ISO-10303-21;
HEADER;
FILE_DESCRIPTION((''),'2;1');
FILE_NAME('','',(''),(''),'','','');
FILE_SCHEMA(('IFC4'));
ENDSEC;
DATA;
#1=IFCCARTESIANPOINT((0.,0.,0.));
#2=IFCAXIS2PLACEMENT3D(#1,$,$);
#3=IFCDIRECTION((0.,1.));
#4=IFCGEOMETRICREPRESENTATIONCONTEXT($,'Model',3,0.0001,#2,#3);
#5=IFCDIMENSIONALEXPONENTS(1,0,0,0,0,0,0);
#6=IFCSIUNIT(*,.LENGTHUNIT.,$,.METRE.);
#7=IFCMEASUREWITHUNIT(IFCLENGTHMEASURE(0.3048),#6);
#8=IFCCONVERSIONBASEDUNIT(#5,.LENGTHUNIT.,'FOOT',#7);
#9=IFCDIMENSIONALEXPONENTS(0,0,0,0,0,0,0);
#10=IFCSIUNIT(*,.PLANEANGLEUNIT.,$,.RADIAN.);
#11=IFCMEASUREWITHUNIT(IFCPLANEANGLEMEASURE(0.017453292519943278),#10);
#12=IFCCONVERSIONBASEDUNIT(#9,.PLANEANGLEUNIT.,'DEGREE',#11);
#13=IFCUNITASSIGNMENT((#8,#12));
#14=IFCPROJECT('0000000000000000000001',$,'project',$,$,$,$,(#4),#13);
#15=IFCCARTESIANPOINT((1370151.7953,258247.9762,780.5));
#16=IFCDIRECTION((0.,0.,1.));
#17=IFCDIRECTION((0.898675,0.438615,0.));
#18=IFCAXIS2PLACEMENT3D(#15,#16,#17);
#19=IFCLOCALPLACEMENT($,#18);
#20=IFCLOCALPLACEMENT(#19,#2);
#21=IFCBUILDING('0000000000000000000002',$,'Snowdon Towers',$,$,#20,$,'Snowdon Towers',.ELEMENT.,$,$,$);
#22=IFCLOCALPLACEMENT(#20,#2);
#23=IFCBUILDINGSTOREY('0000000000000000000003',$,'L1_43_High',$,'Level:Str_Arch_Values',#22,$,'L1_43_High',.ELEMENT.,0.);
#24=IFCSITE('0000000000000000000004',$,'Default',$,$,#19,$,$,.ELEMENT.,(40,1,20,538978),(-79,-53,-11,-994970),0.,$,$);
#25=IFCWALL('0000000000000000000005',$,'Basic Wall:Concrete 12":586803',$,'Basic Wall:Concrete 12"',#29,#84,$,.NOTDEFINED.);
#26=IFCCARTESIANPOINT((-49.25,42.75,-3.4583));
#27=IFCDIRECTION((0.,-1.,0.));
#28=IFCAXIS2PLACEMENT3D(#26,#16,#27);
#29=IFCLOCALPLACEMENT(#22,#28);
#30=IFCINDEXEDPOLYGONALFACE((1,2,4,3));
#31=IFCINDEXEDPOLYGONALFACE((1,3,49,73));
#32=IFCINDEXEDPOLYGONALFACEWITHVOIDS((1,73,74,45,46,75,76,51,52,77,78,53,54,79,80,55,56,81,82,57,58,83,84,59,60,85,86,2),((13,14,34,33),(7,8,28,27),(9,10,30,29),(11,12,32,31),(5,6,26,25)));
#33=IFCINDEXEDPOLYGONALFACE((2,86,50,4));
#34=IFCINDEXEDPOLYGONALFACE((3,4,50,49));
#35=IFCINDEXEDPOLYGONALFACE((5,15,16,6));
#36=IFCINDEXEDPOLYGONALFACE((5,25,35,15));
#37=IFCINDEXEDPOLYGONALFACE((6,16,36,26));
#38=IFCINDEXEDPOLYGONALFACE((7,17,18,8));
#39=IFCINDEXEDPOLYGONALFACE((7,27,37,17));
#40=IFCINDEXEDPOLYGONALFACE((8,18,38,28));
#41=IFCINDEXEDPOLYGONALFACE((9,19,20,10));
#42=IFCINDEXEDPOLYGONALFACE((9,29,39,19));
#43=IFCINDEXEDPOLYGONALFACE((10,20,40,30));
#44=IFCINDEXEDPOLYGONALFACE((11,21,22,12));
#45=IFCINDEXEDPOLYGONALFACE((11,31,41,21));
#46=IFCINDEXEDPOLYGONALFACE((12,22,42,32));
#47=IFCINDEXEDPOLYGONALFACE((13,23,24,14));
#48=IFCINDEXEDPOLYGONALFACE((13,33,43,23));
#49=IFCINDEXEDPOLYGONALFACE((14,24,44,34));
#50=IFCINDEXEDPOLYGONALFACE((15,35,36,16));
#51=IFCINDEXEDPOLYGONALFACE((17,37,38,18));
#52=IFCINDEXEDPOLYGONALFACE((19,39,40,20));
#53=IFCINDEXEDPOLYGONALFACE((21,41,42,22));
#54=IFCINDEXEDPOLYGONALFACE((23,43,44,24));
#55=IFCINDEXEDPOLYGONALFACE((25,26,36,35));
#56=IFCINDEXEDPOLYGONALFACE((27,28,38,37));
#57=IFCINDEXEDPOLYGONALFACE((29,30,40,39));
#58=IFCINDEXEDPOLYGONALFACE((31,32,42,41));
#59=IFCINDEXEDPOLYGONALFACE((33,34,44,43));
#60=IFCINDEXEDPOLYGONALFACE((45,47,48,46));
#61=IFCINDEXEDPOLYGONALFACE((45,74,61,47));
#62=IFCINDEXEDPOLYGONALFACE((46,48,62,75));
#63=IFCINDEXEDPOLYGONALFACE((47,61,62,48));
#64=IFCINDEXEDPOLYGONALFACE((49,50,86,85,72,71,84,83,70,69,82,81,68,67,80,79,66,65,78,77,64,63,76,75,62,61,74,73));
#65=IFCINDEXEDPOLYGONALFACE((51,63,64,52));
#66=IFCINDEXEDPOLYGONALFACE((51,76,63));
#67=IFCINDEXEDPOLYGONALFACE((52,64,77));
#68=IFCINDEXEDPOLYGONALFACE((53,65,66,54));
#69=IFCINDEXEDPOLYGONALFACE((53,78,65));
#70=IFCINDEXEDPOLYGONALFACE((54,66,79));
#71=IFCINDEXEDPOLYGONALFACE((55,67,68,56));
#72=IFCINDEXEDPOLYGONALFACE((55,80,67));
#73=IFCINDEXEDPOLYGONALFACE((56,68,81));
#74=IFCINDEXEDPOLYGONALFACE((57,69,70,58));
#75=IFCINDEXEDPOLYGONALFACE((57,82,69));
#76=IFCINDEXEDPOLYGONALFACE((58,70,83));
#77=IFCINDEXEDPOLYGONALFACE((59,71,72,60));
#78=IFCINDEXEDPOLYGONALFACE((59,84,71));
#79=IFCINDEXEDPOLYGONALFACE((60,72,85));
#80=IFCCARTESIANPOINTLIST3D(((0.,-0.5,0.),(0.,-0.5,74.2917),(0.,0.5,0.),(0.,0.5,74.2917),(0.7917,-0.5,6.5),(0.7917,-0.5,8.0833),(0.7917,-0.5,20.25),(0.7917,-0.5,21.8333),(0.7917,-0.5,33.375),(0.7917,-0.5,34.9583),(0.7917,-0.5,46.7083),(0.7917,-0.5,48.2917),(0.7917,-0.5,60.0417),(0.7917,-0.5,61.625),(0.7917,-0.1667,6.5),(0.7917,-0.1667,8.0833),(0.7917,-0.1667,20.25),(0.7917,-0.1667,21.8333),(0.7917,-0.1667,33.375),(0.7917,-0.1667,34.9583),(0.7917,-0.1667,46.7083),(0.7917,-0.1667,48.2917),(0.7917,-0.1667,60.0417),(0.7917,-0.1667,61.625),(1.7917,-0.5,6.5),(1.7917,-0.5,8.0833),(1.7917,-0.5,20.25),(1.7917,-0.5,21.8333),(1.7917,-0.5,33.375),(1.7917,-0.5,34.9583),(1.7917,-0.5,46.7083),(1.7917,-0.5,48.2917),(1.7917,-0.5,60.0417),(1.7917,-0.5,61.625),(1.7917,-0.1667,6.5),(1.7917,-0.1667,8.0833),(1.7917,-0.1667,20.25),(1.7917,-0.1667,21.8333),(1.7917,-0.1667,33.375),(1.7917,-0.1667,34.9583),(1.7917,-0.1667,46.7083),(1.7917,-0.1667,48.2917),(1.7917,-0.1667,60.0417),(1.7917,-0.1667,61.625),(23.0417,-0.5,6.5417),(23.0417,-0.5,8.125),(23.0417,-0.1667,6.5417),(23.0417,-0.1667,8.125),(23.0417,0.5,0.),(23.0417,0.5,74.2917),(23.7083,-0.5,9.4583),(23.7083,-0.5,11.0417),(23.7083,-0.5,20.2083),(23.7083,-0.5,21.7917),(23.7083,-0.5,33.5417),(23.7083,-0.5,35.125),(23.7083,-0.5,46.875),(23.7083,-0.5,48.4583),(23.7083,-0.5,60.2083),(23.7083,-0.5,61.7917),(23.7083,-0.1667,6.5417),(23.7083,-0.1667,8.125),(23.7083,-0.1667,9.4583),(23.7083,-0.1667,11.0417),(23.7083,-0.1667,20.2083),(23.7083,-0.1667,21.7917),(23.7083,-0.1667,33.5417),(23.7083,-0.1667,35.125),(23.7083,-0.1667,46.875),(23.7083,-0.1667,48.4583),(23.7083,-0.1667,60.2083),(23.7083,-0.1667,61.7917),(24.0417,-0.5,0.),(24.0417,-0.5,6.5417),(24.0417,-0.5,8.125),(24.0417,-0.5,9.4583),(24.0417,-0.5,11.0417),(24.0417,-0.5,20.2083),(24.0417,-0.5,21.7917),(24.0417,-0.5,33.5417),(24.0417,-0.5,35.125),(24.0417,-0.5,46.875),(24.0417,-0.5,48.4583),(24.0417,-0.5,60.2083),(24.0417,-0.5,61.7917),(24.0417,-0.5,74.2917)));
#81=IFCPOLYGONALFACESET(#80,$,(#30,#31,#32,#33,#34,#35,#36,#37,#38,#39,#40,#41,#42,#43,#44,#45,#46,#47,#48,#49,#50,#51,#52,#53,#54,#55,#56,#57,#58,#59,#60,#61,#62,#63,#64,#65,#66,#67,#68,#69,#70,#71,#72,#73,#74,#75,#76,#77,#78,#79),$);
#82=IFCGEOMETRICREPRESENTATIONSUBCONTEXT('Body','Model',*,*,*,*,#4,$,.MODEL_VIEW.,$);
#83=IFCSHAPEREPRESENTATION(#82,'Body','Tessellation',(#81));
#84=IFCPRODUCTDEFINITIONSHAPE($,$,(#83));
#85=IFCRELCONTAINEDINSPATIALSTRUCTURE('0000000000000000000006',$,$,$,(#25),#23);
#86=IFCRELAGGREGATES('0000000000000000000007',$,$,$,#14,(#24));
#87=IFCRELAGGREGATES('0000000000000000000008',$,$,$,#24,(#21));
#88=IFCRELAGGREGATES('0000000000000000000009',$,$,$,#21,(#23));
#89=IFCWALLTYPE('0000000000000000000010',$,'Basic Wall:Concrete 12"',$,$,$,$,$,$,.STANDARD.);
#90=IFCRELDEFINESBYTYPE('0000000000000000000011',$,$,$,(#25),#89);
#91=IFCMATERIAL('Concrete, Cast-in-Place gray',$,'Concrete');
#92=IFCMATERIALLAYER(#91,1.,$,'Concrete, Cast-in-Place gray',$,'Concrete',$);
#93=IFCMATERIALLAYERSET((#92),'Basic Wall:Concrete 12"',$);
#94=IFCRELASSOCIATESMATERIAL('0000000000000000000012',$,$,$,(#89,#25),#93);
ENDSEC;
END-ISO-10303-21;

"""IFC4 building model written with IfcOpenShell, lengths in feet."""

from ifc_helpers import new_model, entity, si_unit, converted_unit, direction, frame, frame_2d, origin, origin_2d_with_axis, place, context, subcontext, project, spatial, polyline, rectangle, outline, extrude, material, layer, layer_set, layer_usage, type_object, element, save


model = new_model("IFC4")

# Units and contexts
model_context = context("Model", 3, precision=0.0001, world=origin(), true_north=direction((0.0, 1.0)))
body_context = subcontext(model_context, "Body", "Model", "MODEL_VIEW")
ifc_project = project(units=[converted_unit("LENGTHUNIT", "FOOT", entity("IfcLengthMeasure", 0.3048), si_unit("LENGTHUNIT", "METRE"), dimensions=[1, 0, 0, 0, 0, 0, 0]), converted_unit("PLANEANGLEUNIT", "DEGREE", entity("IfcPlaneAngleMeasure", 0.017453292519943278), si_unit("PLANEANGLEUNIT", "RADIAN"), dimensions=[0, 0, 0, 0, 0, 0, 0])], contexts=[model_context])

# Site, building, storey
site_placement = place(None, frame((1370151.7953, 258247.9762, 780.5), z_axis=(0.0, 0.0, 1.0), x_axis=(0.898675, 0.438615, 0.0)))
site = spatial("IfcSite", under=ifc_project, at=site_placement, Name="Default", CompositionType="ELEMENT", RefLatitude=(40, 1, 20, 538978), RefLongitude=(-79, -53, -11, -994970), RefElevation=0.0)
building_placement = place(site_placement, origin())
building = spatial("IfcBuilding", under=site, at=building_placement, Name="Snowdon Towers", LongName="Snowdon Towers", CompositionType="ELEMENT")
storey_placement = place(building_placement, origin())
storey = spatial("IfcBuildingStorey", under=building, at=storey_placement, Name="L1_43_High", ObjectType="Level:Str_Arch_Values", LongName="L1_43_High", CompositionType="ELEMENT", Elevation=0.0)

# Shared definitions
ifc_material = material(Name="Concrete, Cast-in-Place gray", Category="Concrete")
ifc_layer = layer(ifc_material, 1.0, Name="Concrete, Cast-in-Place gray", Category="Concrete")
ifc_layer_set = layer_set([ifc_layer], Name="Basic Wall:Concrete 12\"")
wall_type = type_object("IfcWallType", Name="Basic Wall:Concrete 12\"", PredefinedType="STANDARD", material=ifc_layer_set)

# Wall, openings
ifc_layer_usage_1 = layer_usage(ifc_layer_set, "AXIS2", "POSITIVE", -0.5)
wall_1_placement = place(storey_placement, frame((-49.25, 42.75, -3.4583), z_axis=(0.0, 0.0, 1.0), x_axis=(0.0, -1.0, 0.0)))
wall_1 = element("IfcWall", 1, at=wall_1_placement, inside=storey, type_object=wall_type, material=ifc_layer_usage_1, Name="Basic Wall:Concrete 12\":586803", ObjectType="Basic Wall:Concrete 12\"", PredefinedType="NOTDEFINED", context=body_context, shape_type="SweptSolid", body=[
    extrude(outline(polyline([(24.0417, -0.5), (23.0417, 0.5), (0.0, 0.5), (0.0, -0.5), (24.0417, -0.5)])), origin(), (0.0, 0.0, 1.0), 74.2917),
])
opening_1_placement = place(wall_1_placement, origin())
element("IfcOpeningElement", 2, at=opening_1_placement, cuts=wall_1, PredefinedType="OPENING", context=body_context, shape_type="SweptSolid", body=[
    extrude(rectangle(XDim=1.5833, YDim=0.3333, at=frame_2d((0.0, 0.0), x_axis=(0.0, 1.0))), frame((23.875, -0.5, 21.0), z_axis=(0.0, 1.0, 0.0), x_axis=(1.0, 0.0, 0.0)), (0.0, 0.0, 1.0), 1.0),
])
opening_2_placement = place(wall_1_placement, origin())
element("IfcOpeningElement", 3, at=opening_2_placement, cuts=wall_1, PredefinedType="OPENING", context=body_context, shape_type="SweptSolid", body=[
    extrude(rectangle(XDim=1.5833, YDim=0.3333, at=frame_2d((0.0, 0.0), x_axis=(0.0, 1.0))), frame((23.875, -0.5, 10.25), z_axis=(0.0, 1.0, 0.0), x_axis=(1.0, 0.0, 0.0)), (0.0, 0.0, 1.0), 1.0),
])
opening_3_placement = place(wall_1_placement, origin())
element("IfcOpeningElement", 4, at=opening_3_placement, cuts=wall_1, PredefinedType="RECESS", context=body_context, shape_type="SweptSolid", body=[
    extrude(rectangle(XDim=1.5833, YDim=1.0, at=frame_2d((0.0, 0.0), x_axis=(1.0, 0.0))), frame((23.5417, -0.5, 7.3333), z_axis=(0.0, 1.0, 0.0), x_axis=(0.0, 0.0, -1.0)), (0.0, 0.0, 1.0), 0.3333),
])
opening_4_placement = place(wall_1_placement, origin())
element("IfcOpeningElement", 5, at=opening_4_placement, cuts=wall_1, PredefinedType="OPENING", context=body_context, shape_type="SweptSolid", body=[
    extrude(rectangle(XDim=1.5833, YDim=0.3333, at=frame_2d((0.0, 0.0), x_axis=(0.0, 1.0))), frame((23.875, -0.5, 34.3333), z_axis=(0.0, 1.0, 0.0), x_axis=(1.0, 0.0, 0.0)), (0.0, 0.0, 1.0), 1.0),
])
opening_5_placement = place(wall_1_placement, origin())
element("IfcOpeningElement", 6, at=opening_5_placement, cuts=wall_1, PredefinedType="OPENING", context=body_context, shape_type="SweptSolid", body=[
    extrude(rectangle(XDim=1.5833, YDim=0.3333, at=frame_2d((0.0, 0.0), x_axis=(0.0, 1.0))), frame((23.875, -0.5, 47.6667), z_axis=(0.0, 1.0, 0.0), x_axis=(1.0, 0.0, 0.0)), (0.0, 0.0, 1.0), 1.0),
])
opening_6_placement = place(wall_1_placement, origin())
element("IfcOpeningElement", 7, at=opening_6_placement, cuts=wall_1, PredefinedType="OPENING", context=body_context, shape_type="SweptSolid", body=[
    extrude(rectangle(XDim=1.5833, YDim=0.3333, at=frame_2d((0.0, 0.0), x_axis=(0.0, 1.0))), frame((23.875, -0.5, 61.0), z_axis=(0.0, 1.0, 0.0), x_axis=(1.0, 0.0, 0.0)), (0.0, 0.0, 1.0), 1.0),
])
opening_7_placement = place(wall_1_placement, origin())
element("IfcOpeningElement", 8, at=opening_7_placement, cuts=wall_1, PredefinedType="RECESS", context=body_context, shape_type="SweptSolid", body=[
    extrude(rectangle(XDim=1.5833, YDim=1.0, at=frame_2d((0.0, 0.0), x_axis=(1.0, 0.0))), frame((1.2917, -0.5, 21.0417), z_axis=(0.0, 1.0, 0.0), x_axis=(0.0, 0.0, -1.0)), (0.0, 0.0, 1.0), 0.3333),
])
opening_8_placement = place(wall_1_placement, origin())
element("IfcOpeningElement", 9, at=opening_8_placement, cuts=wall_1, PredefinedType="RECESS", context=body_context, shape_type="SweptSolid", body=[
    extrude(rectangle(XDim=1.5833, YDim=1.0, at=frame_2d((0.0, 0.0), x_axis=(1.0, 0.0))), frame((1.2917, -0.5, 7.2917), z_axis=(0.0, 1.0, 0.0), x_axis=(0.0, 0.0, -1.0)), (0.0, 0.0, 1.0), 0.3333),
])
opening_9_placement = place(wall_1_placement, origin())
element("IfcOpeningElement", 10, at=opening_9_placement, cuts=wall_1, PredefinedType="RECESS", context=body_context, shape_type="SweptSolid", body=[
    extrude(rectangle(XDim=1.5833, YDim=1.0, at=frame_2d((0.0, 0.0), x_axis=(1.0, 0.0))), frame((1.2917, -0.5, 34.1667), z_axis=(0.0, 1.0, 0.0), x_axis=(0.0, 0.0, -1.0)), (0.0, 0.0, 1.0), 0.3333),
])
opening_10_placement = place(wall_1_placement, origin())
element("IfcOpeningElement", 11, at=opening_10_placement, cuts=wall_1, PredefinedType="RECESS", context=body_context, shape_type="SweptSolid", body=[
    extrude(rectangle(XDim=1.5833, YDim=1.0, at=origin_2d_with_axis()), frame((1.2917, -0.5, 47.5), z_axis=(0.0, 1.0, 0.0), x_axis=(0.0, 0.0, -1.0)), (0.0, 0.0, 1.0), 0.3333),
])
opening_11_placement = place(wall_1_placement, origin())
element("IfcOpeningElement", 12, at=opening_11_placement, cuts=wall_1, PredefinedType="RECESS", context=body_context, shape_type="SweptSolid", body=[
    extrude(rectangle(XDim=1.5833, YDim=1.0, at=frame_2d((0.0, 0.0), x_axis=(1.0, 0.0))), frame((1.2917, -0.5, 60.8333), z_axis=(0.0, 1.0, 0.0), x_axis=(0.0, 0.0, -1.0)), (0.0, 0.0, 1.0), 0.3333),
])

save(model, "model.ifc")
